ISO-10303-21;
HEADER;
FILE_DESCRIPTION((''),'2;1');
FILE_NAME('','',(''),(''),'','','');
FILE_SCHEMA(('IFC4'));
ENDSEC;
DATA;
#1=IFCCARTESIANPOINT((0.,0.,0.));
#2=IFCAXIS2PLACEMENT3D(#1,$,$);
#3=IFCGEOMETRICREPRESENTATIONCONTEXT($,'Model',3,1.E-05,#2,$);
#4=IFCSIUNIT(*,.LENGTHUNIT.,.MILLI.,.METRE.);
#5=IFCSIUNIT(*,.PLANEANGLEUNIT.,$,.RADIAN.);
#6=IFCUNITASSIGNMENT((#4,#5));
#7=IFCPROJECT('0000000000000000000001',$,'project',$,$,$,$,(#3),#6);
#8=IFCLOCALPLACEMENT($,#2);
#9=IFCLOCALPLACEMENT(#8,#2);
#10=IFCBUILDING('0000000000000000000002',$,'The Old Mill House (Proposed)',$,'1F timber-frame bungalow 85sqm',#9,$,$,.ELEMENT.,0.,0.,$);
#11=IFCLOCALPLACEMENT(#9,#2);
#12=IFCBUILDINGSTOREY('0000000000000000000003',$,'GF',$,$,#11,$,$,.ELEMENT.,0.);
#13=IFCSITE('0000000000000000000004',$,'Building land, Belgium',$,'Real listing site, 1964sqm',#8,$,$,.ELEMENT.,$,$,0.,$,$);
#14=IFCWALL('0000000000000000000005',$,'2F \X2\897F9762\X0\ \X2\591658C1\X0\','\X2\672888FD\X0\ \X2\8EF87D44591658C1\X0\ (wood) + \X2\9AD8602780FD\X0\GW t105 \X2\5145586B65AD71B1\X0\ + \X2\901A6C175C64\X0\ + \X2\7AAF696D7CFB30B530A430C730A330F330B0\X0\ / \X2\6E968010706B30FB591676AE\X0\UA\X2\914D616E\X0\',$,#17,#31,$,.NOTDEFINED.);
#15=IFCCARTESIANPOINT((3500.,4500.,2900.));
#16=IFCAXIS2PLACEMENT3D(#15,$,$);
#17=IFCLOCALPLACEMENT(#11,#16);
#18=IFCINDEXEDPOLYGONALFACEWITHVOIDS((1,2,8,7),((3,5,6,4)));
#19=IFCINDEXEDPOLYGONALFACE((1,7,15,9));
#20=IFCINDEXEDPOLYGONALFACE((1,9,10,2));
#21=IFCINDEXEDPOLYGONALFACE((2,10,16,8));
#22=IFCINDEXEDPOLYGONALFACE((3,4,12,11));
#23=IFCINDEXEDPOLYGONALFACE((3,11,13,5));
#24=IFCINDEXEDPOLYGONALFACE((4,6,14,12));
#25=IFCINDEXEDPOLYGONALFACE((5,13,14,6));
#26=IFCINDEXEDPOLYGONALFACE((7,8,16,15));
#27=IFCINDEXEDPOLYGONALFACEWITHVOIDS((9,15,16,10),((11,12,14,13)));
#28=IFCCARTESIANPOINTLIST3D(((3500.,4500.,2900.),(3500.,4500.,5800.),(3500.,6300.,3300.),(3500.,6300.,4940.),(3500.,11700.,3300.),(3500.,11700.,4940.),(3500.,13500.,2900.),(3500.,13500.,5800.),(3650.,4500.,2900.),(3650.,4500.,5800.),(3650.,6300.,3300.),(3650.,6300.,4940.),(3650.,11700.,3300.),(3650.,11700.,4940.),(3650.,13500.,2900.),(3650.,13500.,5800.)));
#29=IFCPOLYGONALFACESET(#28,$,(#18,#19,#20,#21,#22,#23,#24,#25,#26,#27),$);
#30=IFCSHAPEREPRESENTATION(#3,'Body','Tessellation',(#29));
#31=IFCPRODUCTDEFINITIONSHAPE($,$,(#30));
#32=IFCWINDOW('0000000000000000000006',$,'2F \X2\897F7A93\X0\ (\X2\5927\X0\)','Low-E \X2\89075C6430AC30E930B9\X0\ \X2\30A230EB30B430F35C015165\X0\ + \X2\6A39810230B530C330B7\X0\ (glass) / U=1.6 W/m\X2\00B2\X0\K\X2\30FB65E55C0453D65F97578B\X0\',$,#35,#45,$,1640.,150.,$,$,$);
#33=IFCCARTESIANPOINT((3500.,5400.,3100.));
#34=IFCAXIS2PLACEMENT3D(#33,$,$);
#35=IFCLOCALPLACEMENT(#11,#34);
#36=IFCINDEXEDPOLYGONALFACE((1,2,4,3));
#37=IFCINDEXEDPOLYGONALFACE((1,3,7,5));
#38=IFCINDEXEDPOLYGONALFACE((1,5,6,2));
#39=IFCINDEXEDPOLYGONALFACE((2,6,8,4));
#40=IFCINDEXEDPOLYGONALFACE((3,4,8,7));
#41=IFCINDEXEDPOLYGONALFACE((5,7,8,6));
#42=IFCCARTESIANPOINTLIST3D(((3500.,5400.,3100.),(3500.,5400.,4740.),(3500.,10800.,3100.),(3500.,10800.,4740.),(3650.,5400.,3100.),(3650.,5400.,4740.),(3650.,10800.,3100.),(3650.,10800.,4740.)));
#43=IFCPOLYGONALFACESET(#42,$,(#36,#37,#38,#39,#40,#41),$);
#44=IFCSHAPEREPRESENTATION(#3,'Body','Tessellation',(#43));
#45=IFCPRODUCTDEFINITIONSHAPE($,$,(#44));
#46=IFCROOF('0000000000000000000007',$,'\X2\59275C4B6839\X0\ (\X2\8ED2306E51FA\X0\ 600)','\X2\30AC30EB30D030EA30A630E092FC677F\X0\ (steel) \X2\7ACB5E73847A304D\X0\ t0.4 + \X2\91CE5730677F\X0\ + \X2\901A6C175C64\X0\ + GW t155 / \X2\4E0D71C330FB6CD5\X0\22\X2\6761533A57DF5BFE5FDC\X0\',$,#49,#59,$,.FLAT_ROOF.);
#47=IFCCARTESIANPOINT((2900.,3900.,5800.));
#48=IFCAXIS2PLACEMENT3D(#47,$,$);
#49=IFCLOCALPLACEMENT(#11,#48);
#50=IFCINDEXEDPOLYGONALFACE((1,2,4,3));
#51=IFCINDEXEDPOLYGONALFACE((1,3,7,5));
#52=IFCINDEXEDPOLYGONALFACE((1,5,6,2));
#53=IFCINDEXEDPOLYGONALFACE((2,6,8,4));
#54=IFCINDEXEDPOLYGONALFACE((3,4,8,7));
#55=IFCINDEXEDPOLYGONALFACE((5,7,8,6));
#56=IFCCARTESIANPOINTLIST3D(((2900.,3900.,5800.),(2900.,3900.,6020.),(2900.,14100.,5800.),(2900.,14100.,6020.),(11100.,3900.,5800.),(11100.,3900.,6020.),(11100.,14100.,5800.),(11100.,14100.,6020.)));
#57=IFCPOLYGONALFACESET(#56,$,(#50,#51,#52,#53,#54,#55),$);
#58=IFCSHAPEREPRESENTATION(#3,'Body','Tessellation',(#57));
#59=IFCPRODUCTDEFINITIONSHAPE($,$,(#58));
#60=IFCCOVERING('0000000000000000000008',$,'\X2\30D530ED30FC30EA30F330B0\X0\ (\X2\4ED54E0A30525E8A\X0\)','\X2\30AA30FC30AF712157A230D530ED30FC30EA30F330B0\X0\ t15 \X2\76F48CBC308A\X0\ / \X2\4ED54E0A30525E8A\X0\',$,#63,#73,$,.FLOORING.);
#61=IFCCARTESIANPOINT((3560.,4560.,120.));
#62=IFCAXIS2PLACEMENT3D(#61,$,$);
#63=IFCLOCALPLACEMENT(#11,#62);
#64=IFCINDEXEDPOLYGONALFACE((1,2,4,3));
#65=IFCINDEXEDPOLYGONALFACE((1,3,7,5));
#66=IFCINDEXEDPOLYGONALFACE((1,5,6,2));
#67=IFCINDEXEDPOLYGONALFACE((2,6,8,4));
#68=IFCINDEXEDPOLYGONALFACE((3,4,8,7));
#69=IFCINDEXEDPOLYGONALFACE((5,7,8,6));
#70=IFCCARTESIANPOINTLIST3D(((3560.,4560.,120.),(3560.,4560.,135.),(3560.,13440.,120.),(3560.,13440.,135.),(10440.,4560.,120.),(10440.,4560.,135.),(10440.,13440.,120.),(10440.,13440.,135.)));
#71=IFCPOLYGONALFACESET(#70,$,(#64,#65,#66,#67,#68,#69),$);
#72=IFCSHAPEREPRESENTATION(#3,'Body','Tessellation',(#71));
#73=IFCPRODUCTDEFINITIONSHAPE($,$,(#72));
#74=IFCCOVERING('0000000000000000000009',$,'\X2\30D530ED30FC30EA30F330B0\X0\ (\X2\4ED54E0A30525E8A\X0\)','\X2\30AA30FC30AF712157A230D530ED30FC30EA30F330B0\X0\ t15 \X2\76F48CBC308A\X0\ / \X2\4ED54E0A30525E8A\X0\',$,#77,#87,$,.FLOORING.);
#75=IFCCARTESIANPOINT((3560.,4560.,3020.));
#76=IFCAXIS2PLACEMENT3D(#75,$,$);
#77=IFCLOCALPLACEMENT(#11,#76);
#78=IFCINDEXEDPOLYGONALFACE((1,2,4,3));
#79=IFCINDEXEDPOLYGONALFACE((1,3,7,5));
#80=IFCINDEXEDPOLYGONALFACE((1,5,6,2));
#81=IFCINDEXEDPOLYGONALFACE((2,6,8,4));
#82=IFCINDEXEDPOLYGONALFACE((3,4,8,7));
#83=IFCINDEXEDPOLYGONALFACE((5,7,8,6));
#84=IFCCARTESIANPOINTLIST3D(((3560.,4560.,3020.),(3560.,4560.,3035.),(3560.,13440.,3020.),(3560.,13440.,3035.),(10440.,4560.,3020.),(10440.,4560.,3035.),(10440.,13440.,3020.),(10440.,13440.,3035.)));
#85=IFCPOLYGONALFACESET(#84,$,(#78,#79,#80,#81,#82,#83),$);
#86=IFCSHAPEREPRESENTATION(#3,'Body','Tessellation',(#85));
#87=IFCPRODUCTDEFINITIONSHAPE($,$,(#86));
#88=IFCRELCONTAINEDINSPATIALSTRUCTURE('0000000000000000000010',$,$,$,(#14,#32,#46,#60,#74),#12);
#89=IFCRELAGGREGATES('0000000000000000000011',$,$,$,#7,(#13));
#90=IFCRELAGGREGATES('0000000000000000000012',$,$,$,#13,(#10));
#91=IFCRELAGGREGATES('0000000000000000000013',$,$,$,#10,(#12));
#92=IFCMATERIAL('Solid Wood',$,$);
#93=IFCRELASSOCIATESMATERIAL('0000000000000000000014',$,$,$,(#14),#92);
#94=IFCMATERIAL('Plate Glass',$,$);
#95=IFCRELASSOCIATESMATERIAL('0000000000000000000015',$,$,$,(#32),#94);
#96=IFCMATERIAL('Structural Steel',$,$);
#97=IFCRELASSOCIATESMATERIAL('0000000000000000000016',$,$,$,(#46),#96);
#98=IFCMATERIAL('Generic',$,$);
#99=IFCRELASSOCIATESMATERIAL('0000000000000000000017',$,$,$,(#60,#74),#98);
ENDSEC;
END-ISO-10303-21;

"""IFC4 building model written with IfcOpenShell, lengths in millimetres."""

from ifc_helpers import new_model, si_unit, frame, frame_2d, origin, place, context, project, spatial, rectangle, extrude, material, element, fill, save


model = new_model("IFC4")

# Units and contexts
model_context = context("Model", 3, precision=1e-05, world=origin())
ifc_project = project(units=[si_unit("LENGTHUNIT", "METRE", prefix="MILLI"), si_unit("PLANEANGLEUNIT", "RADIAN")], contexts=[model_context])

# Site, building, storey
site_placement = place(None, origin())
site = spatial("IfcSite", under=ifc_project, at=site_placement, Name="Building land, Belgium", ObjectType="Real listing site, 1964sqm", CompositionType="ELEMENT", RefElevation=0.0)
building_placement = place(site_placement, origin())
building = spatial("IfcBuilding", under=site, at=building_placement, Name="The Old Mill House (Proposed)", ObjectType="1F timber-frame bungalow 85sqm", CompositionType="ELEMENT", ElevationOfRefHeight=0.0, ElevationOfTerrain=0.0)
storey_placement = place(building_placement, origin())
storey = spatial("IfcBuildingStorey", under=building, at=storey_placement, Name="GF", CompositionType="ELEMENT", Elevation=0.0)

# Shared definitions
ifc_material_1 = material(Name="Solid Wood")
ifc_material_2 = material(Name="Generic")

# Shared definitions
ifc_material_3 = material(Name="Plate Glass")

# Wall, opening, window
wall_1_placement = place(storey_placement, frame((3500.0, 4500.0, 2900.0)))
wall_1 = element("IfcWall", 1, at=wall_1_placement, inside=storey, material=ifc_material_1, Name="2F 西面 外壁", Description="木製 軸組外壁 (wood) + 高性能GW t105 充填断熱 + 通気層 + 窯業系サイディング / 準耐火・外皮UA配慮", PredefinedType="NOTDEFINED", context=model_context, shape_type="SweptSolid", body=[
    extrude(rectangle(XDim=150.0, YDim=9000.0, at=frame_2d((75.0, 4500.0))), frame((3500.0, 4500.0, 2900.0)), (0.0, 0.0, 1.0), 2900.0),
])
opening_1_placement = place(storey_placement, frame((3500.0, 5400.0, 3100.0)))
opening_1 = element("IfcOpeningElement", 2, at=opening_1_placement, cuts=wall_1, PredefinedType="NOTDEFINED", context=model_context, shape_type="SweptSolid", body=[
    extrude(rectangle(XDim=150.0, YDim=5400.0, at=frame_2d((75.0, 2700.0))), frame((3500.0, 5400.0, 3100.0)), (0.0, 0.0, 1.0), 1640.0),
])
window_1_placement = place(storey_placement, frame((3500.0, 5400.0, 3100.0)))
window_1 = element("IfcWindow", 3, at=window_1_placement, inside=storey, material=ifc_material_3, Name="2F 西窓 (大)", Description="Low-E 複層ガラス アルゴン封入 + 樹脂サッシ (glass) / U=1.6 W/m²K・日射取得型", OverallHeight=1640.0, OverallWidth=150.0, context=model_context, shape_type="SweptSolid", body=[
    extrude(rectangle(XDim=150.0, YDim=5400.0, at=frame_2d((75.0, 2700.0))), frame((3500.0, 5400.0, 3100.0)), (0.0, 0.0, 1.0), 1640.0),
])
fill(opening_1, window_1)

# Roof
ifc_material_4 = material(Name="Structural Steel")
roof_placement = place(storey_placement, frame((2900.0, 3900.0, 5800.0)))
element("IfcRoof", 4, at=roof_placement, inside=storey, material=ifc_material_4, Name="大屋根 (軒の出 600)", Description="ガルバリウム鋼板 (steel) 立平葺き t0.4 + 野地板 + 通気層 + GW t155 / 不燃・法22条区域対応", PredefinedType="FLAT_ROOF", context=model_context, shape_type="SweptSolid", body=[
    extrude(rectangle(XDim=8200.0, YDim=10200.0, at=frame_2d((4100.0, 5100.0))), frame((2900.0, 3900.0, 5800.0)), (0.0, 0.0, 1.0), 220.0),
])

# Coverings
covering_1_placement = place(storey_placement, frame((3560.0, 4560.0, 120.0)))
element("IfcCovering", 5, at=covering_1_placement, inside=storey, material=ifc_material_2, Name="フローリング (仕上げ床)", Description="オーク無垢フローリング t15 直貼り / 仕上げ床", PredefinedType="FLOORING", context=model_context, shape_type="SweptSolid", body=[
    extrude(rectangle(XDim=6880.0, YDim=8880.0, at=frame_2d((3440.0, 4440.0))), frame((3560.0, 4560.0, 120.0)), (0.0, 0.0, 1.0), 15.0),
])
covering_2_placement = place(storey_placement, frame((3560.0, 4560.0, 3020.0)))
element("IfcCovering", 6, at=covering_2_placement, inside=storey, material=ifc_material_2, Name="フローリング (仕上げ床)", Description="オーク無垢フローリング t15 直貼り / 仕上げ床", PredefinedType="FLOORING", context=model_context, shape_type="SweptSolid", body=[
    extrude(rectangle(XDim=6880.0, YDim=8880.0, at=frame_2d((3440.0, 4440.0))), frame((3560.0, 4560.0, 3020.0)), (0.0, 0.0, 1.0), 15.0),
])

save(model, "model.ifc")
